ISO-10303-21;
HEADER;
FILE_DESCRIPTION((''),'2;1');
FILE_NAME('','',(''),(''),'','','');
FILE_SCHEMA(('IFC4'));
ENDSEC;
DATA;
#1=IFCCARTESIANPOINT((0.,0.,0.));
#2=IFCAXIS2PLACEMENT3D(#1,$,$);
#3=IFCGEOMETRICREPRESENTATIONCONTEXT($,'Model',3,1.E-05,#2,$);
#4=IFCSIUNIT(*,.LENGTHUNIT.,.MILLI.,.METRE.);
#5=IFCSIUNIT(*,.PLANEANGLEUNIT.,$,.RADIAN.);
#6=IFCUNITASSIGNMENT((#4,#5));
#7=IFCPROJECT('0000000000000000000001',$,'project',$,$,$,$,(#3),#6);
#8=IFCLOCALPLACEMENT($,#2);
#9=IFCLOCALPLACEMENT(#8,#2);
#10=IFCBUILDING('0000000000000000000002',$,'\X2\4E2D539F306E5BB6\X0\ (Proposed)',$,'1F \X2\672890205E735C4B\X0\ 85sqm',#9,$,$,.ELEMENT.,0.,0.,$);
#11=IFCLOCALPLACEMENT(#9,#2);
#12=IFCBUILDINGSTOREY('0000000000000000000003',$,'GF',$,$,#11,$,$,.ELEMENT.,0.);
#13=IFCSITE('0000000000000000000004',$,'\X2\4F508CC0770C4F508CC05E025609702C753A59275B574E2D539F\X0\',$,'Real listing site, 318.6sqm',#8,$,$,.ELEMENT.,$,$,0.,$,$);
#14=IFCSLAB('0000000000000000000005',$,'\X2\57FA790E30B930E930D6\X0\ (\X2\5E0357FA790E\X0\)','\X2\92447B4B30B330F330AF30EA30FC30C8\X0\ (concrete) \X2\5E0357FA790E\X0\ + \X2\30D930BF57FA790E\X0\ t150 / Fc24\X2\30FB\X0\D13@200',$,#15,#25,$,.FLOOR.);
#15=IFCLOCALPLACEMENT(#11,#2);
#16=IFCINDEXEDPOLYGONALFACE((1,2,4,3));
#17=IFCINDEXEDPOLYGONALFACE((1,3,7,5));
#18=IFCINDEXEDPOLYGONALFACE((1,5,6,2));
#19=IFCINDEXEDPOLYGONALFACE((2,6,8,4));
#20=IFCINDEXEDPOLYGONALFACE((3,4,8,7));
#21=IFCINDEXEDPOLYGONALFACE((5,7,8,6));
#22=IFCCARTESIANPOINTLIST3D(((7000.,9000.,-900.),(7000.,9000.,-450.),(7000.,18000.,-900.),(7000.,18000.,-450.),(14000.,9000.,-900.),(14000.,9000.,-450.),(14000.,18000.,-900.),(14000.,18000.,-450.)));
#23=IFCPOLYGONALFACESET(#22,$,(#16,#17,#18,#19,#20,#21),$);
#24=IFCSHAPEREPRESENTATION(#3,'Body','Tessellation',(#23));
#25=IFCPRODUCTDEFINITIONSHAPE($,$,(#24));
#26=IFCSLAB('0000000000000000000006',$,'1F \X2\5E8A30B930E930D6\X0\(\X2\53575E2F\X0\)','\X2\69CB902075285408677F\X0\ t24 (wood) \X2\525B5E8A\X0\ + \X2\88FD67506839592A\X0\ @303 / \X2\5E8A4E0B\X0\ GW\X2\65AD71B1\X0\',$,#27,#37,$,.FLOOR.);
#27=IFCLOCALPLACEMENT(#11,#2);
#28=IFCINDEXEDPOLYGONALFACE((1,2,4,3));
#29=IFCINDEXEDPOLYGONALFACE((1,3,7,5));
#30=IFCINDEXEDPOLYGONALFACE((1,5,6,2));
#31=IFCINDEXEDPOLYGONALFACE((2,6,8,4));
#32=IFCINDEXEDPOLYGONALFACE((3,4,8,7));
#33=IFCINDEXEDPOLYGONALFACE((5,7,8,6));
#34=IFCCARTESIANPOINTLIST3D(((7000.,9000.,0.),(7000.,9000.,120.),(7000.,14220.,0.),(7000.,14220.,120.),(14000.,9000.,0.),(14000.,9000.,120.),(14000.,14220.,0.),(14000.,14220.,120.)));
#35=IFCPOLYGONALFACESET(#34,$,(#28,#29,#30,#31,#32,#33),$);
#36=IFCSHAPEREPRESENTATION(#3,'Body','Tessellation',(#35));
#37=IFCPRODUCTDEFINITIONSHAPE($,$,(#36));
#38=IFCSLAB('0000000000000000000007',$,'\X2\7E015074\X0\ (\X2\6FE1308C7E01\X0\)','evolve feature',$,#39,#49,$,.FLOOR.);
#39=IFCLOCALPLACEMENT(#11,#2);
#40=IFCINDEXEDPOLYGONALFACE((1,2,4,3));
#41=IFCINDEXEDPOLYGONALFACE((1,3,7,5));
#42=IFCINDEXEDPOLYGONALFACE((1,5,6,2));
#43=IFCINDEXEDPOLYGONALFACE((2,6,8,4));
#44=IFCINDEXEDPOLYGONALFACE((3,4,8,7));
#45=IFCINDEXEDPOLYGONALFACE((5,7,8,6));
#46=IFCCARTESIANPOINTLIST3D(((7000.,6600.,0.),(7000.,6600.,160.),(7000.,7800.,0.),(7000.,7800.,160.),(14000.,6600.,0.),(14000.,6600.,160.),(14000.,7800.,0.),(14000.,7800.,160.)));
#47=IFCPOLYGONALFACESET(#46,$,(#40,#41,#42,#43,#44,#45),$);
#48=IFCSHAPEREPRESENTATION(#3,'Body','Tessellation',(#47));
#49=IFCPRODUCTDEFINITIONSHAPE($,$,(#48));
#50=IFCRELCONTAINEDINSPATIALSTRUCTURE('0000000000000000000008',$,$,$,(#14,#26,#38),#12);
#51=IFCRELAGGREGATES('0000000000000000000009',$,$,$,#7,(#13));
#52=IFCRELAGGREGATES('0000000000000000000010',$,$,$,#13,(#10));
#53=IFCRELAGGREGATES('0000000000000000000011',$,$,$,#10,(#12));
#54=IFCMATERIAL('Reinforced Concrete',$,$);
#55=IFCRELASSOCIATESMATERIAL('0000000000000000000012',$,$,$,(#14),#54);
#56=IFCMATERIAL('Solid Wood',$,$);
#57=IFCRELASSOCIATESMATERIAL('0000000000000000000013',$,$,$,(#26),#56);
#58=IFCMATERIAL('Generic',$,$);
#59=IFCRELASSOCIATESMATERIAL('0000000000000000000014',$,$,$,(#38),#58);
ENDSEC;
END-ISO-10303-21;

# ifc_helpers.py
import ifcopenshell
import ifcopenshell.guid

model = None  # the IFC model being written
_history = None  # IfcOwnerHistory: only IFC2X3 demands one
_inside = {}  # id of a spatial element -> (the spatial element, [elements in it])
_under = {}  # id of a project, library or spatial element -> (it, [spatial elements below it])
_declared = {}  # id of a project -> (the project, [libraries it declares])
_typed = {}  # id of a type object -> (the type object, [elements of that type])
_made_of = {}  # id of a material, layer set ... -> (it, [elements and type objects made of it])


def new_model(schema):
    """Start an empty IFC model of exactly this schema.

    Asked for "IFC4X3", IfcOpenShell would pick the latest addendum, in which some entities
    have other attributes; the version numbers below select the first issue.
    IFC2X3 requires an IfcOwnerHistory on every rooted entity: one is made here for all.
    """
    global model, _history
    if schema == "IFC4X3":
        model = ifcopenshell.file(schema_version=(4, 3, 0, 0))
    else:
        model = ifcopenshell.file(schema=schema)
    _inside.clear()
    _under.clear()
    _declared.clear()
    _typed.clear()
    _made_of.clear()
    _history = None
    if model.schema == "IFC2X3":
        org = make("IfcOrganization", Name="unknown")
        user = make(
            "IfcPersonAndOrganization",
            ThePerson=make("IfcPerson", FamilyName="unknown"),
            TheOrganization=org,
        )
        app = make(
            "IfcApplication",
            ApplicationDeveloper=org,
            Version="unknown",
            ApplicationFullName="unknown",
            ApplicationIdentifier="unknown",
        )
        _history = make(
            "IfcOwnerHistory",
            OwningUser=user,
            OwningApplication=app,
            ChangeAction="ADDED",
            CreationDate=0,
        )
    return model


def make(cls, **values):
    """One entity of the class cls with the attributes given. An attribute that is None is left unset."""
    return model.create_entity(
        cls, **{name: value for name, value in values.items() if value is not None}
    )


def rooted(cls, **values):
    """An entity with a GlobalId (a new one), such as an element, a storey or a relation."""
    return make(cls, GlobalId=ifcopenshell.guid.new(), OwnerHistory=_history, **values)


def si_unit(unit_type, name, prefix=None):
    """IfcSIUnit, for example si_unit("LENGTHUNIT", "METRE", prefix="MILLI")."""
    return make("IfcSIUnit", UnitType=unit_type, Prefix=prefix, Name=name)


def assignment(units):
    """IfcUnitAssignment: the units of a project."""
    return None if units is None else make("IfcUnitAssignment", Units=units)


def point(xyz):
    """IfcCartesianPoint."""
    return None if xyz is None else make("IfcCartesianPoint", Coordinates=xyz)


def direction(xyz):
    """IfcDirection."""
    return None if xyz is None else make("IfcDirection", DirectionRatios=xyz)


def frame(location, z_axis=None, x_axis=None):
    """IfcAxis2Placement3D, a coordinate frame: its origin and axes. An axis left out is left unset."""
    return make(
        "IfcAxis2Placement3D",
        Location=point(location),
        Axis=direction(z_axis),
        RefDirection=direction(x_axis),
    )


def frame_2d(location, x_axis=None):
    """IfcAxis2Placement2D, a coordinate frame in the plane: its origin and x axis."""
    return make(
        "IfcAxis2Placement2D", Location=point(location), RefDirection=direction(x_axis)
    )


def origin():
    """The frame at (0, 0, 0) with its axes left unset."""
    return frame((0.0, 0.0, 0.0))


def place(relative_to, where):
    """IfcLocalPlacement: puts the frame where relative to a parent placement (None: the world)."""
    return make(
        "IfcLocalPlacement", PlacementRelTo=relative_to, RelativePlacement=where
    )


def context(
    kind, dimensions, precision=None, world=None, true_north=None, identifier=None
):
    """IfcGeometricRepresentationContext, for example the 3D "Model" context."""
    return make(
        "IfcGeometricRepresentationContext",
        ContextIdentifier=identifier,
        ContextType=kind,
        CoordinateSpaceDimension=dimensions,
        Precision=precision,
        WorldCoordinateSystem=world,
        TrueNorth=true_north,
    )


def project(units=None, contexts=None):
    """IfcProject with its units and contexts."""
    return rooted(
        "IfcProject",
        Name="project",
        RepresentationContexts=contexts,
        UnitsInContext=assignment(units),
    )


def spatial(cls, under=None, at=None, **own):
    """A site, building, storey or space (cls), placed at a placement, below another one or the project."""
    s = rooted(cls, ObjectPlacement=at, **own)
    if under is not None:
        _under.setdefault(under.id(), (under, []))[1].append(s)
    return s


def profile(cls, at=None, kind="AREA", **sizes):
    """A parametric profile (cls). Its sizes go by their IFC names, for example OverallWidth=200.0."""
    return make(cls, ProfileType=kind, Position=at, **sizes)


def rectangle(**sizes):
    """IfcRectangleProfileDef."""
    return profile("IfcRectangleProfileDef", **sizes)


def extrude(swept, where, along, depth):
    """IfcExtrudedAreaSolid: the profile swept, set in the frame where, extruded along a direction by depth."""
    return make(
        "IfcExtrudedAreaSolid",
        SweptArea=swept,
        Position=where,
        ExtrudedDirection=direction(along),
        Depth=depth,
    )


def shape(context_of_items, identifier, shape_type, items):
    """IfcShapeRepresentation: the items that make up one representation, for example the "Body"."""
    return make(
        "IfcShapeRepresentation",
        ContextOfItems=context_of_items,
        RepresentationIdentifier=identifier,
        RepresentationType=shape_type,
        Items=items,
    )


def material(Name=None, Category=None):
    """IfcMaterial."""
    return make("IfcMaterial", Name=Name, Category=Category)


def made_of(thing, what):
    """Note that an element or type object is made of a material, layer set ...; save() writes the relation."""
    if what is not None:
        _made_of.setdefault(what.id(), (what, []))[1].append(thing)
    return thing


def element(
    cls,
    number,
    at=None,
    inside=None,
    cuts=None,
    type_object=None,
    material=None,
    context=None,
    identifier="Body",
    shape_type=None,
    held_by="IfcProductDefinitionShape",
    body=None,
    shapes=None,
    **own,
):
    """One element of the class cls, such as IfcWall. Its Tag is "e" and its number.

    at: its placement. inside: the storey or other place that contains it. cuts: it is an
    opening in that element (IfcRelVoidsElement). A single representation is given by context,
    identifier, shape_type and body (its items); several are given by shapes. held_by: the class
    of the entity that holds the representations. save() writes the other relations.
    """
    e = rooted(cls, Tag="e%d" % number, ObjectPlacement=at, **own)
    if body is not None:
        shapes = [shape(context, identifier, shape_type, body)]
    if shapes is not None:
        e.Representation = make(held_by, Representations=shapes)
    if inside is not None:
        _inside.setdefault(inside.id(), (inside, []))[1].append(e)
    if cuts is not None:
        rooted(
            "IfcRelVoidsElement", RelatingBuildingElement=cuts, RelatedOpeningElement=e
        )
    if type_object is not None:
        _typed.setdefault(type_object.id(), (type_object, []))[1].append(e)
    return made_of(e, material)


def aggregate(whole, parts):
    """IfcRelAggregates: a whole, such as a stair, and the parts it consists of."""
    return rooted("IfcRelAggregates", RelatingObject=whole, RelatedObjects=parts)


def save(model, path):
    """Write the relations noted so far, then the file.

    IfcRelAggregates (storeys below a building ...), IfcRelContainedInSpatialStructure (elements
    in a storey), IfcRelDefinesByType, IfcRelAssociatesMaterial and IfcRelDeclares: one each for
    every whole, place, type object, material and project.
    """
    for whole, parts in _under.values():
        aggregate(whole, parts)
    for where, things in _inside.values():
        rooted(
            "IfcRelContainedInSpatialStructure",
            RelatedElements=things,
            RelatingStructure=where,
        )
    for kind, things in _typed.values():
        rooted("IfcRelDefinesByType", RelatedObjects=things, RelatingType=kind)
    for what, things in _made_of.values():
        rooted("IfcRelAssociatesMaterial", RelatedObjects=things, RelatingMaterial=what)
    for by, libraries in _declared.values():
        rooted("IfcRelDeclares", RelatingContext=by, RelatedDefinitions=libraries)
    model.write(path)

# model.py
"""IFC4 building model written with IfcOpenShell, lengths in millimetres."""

from ifc_helpers import new_model, si_unit, frame, frame_2d, origin, place, context, project, spatial, rectangle, extrude, material, element, save


model = new_model("IFC4")

# Units and contexts
model_context = context("Model", 3, precision=1e-05, world=origin())
ifc_project = project(units=[si_unit("LENGTHUNIT", "METRE", prefix="MILLI"), si_unit("PLANEANGLEUNIT", "RADIAN")], contexts=[model_context])

# Site, building, storey
site_placement = place(None, origin())
site = spatial("IfcSite", under=ifc_project, at=site_placement, Name="佐賀県佐賀市嘉瀬町大字中原", ObjectType="Real listing site, 318.6sqm", CompositionType="ELEMENT", RefElevation=0.0)
building_placement = place(site_placement, origin())
building = spatial("IfcBuilding", under=site, at=building_placement, Name="中原の家 (Proposed)", ObjectType="1F 木造平屋 85sqm", CompositionType="ELEMENT", ElevationOfRefHeight=0.0, ElevationOfTerrain=0.0)
storey_placement = place(building_placement, origin())
storey = spatial("IfcBuildingStorey", under=building, at=storey_placement, Name="GF", CompositionType="ELEMENT", Elevation=0.0)

# Slabs
ifc_material_1 = material(Name="Reinforced Concrete")
slab_1_placement = place(storey_placement, frame((3500.0, 4500.0, -450.0)))
element("IfcSlab", 1, at=slab_1_placement, inside=storey, material=ifc_material_1, Name="基礎スラブ (布基礎)", Description="鉄筋コンクリート (concrete) 布基礎 + ベタ基礎 t150 / Fc24・D13@200", PredefinedType="FLOOR", context=model_context, shape_type="SweptSolid", body=[
    extrude(rectangle(XDim=7000.0, YDim=9000.0, at=frame_2d((3500.0, 4500.0))), frame((3500.0, 4500.0, -450.0)), (0.0, 0.0, 1.0), 450.0),
])
ifc_material_2 = material(Name="Solid Wood")
slab_2_placement = place(storey_placement, frame((3500.0, 4500.0, 0.0)))
element("IfcSlab", 2, at=slab_2_placement, inside=storey, material=ifc_material_2, Name="1F 床スラブ(南帯)", Description="構造用合板 t24 (wood) 剛床 + 製材根太 @303 / 床下 GW断熱", PredefinedType="FLOOR", context=model_context, shape_type="SweptSolid", body=[
    extrude(rectangle(XDim=7000.0, YDim=5220.0, at=frame_2d((3500.0, 2610.0))), frame((3500.0, 4500.0, 0.0)), (0.0, 0.0, 1.0), 120.0),
])
ifc_material_3 = material(Name="Generic")
slab_3_placement = place(storey_placement, frame((3500.0, 3300.0, 0.0)))
element("IfcSlab", 3, at=slab_3_placement, inside=storey, material=ifc_material_3, Name="縁側 (濡れ縁)", Description="evolve feature", PredefinedType="FLOOR", context=model_context, shape_type="SweptSolid", body=[
    extrude(rectangle(XDim=7000.0, YDim=1200.0, at=frame_2d((3500.0, 600.0))), frame((3500.0, 3300.0, 0.0)), (0.0, 0.0, 1.0), 160.0),
])

save(model, "model.ifc")
